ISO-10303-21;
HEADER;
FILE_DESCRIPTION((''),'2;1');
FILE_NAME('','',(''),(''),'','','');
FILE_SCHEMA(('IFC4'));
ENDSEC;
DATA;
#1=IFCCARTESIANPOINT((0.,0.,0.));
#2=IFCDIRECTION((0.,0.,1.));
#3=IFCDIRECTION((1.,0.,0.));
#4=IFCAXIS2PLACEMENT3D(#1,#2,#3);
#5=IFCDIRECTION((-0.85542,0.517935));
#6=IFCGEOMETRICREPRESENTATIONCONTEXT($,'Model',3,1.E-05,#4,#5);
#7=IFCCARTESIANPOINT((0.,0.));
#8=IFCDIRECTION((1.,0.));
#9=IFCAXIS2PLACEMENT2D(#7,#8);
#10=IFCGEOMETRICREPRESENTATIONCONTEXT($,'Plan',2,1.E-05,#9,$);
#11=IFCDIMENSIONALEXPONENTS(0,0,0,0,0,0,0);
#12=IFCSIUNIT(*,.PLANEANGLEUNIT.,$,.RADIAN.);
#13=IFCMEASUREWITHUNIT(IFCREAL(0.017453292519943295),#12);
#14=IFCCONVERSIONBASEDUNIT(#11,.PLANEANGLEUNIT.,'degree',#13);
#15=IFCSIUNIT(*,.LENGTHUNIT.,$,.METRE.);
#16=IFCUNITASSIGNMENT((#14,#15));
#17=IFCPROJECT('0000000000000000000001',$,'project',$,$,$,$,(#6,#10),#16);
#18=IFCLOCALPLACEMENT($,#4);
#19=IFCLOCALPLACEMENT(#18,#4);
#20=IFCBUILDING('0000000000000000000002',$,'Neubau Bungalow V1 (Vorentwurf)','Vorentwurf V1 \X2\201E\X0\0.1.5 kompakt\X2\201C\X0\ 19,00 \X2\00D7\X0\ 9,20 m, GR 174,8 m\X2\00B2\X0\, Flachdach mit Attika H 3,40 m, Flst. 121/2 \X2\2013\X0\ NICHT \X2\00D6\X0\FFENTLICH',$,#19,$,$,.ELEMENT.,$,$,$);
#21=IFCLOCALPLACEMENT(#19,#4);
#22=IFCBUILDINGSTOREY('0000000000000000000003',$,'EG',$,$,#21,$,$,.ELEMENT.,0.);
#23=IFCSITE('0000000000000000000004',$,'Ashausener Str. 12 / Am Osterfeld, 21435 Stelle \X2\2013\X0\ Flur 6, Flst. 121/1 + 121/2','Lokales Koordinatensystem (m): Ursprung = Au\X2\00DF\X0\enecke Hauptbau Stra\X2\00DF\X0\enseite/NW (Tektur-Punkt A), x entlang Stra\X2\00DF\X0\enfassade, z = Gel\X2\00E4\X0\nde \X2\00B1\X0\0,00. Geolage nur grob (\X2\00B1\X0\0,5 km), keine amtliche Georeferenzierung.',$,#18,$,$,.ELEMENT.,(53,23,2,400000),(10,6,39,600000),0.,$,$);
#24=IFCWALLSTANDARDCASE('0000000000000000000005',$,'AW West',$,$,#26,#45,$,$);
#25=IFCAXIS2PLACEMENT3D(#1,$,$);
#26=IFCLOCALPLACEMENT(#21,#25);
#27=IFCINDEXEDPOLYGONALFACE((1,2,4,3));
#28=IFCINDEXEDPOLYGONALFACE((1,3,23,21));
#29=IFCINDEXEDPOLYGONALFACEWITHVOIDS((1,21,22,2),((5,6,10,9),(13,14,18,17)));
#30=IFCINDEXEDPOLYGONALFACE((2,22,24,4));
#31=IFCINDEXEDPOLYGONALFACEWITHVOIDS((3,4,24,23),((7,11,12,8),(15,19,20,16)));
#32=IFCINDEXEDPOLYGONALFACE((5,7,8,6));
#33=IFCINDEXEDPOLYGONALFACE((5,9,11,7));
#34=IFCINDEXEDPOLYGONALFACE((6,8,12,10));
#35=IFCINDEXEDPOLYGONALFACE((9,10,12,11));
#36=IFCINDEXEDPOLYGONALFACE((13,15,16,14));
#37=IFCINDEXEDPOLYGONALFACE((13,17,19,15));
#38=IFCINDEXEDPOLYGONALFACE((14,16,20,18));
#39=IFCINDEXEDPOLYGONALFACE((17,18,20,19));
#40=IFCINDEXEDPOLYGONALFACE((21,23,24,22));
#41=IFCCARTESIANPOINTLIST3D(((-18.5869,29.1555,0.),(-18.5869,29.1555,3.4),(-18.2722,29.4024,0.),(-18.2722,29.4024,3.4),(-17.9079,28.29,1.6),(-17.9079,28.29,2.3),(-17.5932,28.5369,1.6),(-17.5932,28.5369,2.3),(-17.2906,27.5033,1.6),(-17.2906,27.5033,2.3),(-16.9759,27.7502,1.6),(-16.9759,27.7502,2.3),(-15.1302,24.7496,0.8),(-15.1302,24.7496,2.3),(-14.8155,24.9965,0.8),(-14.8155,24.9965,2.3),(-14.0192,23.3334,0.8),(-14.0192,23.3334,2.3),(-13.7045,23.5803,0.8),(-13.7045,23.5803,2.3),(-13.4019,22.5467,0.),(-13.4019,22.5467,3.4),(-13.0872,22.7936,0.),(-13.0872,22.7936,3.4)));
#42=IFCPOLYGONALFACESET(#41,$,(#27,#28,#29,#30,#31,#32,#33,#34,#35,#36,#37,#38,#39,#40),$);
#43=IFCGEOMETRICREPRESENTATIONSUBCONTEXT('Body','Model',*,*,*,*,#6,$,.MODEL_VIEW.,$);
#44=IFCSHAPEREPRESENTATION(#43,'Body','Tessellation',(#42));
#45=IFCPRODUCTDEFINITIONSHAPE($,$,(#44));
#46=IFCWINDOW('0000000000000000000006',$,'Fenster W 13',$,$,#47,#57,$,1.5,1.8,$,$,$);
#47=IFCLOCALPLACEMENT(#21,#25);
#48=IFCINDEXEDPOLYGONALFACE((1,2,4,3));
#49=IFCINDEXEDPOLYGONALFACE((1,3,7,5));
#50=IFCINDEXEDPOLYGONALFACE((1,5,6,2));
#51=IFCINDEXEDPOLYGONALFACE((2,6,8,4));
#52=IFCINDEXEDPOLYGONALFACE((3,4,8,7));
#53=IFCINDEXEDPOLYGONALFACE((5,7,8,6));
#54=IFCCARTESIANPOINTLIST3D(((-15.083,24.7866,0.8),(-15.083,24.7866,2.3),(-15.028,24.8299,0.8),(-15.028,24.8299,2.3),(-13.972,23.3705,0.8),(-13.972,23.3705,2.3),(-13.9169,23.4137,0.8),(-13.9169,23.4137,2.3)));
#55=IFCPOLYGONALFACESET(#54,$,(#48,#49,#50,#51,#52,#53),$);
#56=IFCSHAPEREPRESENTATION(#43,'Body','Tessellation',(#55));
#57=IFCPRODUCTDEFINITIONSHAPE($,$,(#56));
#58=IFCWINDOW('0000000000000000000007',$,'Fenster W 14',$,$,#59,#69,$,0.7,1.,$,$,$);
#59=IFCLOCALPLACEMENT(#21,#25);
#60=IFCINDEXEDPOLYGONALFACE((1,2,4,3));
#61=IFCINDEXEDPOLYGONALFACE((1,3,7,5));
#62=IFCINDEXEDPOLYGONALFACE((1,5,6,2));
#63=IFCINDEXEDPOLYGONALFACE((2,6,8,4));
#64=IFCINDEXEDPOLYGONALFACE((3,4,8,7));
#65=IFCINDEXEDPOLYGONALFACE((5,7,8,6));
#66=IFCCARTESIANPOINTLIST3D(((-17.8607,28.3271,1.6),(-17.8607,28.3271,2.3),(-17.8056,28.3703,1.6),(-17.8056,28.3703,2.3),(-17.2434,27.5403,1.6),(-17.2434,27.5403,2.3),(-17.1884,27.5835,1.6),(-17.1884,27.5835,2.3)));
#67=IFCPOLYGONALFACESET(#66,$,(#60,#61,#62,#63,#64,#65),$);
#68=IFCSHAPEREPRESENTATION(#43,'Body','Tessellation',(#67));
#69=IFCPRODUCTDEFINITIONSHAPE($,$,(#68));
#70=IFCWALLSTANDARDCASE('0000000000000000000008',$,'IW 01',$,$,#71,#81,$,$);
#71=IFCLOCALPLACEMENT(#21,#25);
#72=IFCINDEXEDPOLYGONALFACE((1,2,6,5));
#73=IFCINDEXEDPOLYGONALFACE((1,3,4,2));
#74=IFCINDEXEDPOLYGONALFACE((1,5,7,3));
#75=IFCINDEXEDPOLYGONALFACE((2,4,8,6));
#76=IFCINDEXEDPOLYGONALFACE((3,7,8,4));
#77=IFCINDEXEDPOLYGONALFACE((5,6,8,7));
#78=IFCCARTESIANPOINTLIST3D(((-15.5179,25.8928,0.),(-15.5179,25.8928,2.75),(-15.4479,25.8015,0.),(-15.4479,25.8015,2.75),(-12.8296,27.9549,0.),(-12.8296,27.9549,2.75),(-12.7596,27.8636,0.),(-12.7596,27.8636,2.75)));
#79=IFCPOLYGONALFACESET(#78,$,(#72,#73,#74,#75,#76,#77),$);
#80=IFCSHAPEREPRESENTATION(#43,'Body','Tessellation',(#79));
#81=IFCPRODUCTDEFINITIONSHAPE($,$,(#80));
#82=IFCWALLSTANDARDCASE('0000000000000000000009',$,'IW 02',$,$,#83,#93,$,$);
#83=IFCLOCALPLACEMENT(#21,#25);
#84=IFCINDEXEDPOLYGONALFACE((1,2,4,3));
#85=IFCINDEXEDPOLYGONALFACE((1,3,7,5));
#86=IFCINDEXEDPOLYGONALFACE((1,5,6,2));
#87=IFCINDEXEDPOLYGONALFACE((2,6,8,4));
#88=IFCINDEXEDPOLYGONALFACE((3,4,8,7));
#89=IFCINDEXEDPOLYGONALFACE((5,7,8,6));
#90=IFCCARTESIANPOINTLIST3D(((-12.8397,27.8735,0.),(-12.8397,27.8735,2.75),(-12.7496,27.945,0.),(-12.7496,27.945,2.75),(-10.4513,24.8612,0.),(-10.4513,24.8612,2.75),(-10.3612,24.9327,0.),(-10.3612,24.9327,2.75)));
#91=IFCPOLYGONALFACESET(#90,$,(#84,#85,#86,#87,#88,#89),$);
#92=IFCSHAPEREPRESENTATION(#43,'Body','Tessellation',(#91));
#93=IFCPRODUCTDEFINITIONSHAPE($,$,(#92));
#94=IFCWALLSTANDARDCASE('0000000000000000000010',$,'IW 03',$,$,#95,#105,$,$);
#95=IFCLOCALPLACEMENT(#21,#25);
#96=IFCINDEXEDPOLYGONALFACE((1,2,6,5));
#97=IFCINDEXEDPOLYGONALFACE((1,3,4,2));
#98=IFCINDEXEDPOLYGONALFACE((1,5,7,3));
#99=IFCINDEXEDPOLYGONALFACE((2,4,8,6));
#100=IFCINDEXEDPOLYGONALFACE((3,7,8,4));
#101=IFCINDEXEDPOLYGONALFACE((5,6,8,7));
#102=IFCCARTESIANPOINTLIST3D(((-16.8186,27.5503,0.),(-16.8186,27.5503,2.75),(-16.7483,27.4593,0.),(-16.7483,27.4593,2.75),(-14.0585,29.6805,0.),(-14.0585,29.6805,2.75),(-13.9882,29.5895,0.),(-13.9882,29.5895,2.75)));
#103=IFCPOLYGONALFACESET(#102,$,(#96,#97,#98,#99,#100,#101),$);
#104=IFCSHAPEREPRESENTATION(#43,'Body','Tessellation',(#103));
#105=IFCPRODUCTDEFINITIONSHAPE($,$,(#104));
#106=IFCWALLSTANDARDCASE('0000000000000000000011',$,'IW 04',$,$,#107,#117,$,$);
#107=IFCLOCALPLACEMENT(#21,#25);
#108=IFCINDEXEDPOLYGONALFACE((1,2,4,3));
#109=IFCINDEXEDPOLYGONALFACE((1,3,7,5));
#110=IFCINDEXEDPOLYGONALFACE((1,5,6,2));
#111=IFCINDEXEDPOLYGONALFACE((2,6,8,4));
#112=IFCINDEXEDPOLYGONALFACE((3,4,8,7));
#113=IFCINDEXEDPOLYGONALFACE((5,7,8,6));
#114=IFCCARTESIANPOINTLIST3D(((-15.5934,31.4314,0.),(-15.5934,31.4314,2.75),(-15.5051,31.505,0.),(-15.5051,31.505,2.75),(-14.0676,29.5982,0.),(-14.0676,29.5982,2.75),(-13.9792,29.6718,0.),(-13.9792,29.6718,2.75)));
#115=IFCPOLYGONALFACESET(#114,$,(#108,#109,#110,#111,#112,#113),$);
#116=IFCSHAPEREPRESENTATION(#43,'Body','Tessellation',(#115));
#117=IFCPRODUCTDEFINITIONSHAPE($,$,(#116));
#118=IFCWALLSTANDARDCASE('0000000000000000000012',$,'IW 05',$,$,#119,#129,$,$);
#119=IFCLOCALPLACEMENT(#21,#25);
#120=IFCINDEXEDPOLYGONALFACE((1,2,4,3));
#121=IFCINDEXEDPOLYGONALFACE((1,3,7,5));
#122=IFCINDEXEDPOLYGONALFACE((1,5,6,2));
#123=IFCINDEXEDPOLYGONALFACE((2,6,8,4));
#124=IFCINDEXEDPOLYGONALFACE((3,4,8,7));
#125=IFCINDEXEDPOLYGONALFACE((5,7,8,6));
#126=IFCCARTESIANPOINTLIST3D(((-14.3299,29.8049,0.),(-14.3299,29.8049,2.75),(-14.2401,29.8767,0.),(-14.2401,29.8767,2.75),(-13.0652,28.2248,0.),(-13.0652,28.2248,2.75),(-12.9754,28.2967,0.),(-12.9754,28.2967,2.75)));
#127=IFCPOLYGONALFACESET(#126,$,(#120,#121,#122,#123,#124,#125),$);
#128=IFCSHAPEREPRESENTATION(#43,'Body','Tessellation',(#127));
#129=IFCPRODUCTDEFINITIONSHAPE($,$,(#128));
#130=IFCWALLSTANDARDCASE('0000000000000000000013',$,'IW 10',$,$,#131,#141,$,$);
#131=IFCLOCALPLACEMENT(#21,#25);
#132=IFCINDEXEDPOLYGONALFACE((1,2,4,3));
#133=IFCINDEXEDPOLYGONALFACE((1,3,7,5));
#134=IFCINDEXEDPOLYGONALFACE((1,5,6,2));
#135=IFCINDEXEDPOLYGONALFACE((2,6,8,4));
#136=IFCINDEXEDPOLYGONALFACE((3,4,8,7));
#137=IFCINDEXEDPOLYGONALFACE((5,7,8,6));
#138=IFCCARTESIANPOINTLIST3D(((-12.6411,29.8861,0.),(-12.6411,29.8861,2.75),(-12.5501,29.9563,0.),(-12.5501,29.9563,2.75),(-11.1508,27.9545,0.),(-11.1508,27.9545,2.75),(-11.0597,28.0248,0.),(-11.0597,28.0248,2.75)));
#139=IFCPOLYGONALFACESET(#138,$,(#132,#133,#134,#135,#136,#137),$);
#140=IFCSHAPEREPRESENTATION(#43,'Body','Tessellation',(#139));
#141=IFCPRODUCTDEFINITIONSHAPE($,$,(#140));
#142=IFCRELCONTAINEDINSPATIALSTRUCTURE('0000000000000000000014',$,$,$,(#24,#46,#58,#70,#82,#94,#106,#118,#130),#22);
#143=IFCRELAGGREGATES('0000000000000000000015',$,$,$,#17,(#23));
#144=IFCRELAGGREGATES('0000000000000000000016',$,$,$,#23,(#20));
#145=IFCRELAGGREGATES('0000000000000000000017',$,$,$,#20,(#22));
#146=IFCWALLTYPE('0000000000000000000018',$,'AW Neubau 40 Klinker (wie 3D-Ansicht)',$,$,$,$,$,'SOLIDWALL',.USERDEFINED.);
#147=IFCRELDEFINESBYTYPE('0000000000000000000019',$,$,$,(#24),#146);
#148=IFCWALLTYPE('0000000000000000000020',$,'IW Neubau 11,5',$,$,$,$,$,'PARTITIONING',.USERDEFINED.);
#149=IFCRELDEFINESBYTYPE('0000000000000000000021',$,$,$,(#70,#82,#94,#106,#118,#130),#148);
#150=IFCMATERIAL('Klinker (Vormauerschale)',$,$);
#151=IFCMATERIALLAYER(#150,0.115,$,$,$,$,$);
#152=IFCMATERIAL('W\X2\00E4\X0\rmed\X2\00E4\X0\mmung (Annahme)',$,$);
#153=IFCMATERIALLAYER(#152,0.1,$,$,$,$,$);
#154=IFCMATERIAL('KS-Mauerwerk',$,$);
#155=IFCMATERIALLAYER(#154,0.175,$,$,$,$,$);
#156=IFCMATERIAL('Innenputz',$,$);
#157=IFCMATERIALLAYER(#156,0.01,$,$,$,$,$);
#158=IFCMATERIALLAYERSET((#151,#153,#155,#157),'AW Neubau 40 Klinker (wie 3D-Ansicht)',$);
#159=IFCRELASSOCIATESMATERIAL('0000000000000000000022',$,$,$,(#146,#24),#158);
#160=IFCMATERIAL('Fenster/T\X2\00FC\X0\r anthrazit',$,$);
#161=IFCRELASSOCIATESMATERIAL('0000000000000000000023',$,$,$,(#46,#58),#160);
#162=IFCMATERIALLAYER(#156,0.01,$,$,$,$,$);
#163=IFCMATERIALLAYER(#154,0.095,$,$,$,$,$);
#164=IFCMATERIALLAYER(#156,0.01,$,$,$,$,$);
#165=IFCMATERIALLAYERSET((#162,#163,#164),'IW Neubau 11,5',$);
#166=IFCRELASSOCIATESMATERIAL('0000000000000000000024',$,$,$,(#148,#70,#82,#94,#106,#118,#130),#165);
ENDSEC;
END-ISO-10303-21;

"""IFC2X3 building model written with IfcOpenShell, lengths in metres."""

from ifc_helpers import new_model, entity, si_unit, converted_unit, direction, frame, origin_with_axes, origin_2d_with_axis, place, context, subcontext, project, spatial, polyline, outline, extrude, material, layer, layer_set, layer_usage, type_object, element, fill, save


model = new_model("IFC2X3")

# Units and contexts
model_context = context("Model", 3, precision=1e-05, world=origin_with_axes(), true_north=direction((-0.85542, 0.517935)))
plan_context = context("Plan", 2, precision=1e-05, world=origin_2d_with_axis())
body_context = subcontext(model_context, "Body", "Model", "MODEL_VIEW")
ifc_project = project(units=[converted_unit("PLANEANGLEUNIT", "degree", entity("IfcReal", 0.017453292519943295), si_unit("PLANEANGLEUNIT", "RADIAN"), dimensions=[0, 0, 0, 0, 0, 0, 0]), si_unit("LENGTHUNIT", "METRE")], contexts=[model_context, plan_context])

# Site, building, storey
site_placement = place(None, origin_with_axes())
site = spatial("IfcSite", under=ifc_project, at=site_placement, Name="Ashausener Str. 12 / Am Osterfeld, 21435 Stelle – Flur 6, Flst. 121/1 + 121/2", Description="Lokales Koordinatensystem (m): Ursprung = Außenecke Hauptbau Straßenseite/NW (Tektur-Punkt A), x entlang Straßenfassade, z = Gelände ±0,00. Geolage nur grob (±0,5 km), keine amtliche Georeferenzierung.", CompositionType="ELEMENT", RefLatitude=(53, 23, 2, 400000), RefLongitude=(10, 6, 39, 600000), RefElevation=0.0)
building_placement = place(site_placement, origin_with_axes())
building = spatial("IfcBuilding", under=site, at=building_placement, Name="Neubau Bungalow V1 (Vorentwurf)", Description="Vorentwurf V1 „0.1.5 kompakt“ 19,00 × 9,20 m, GR 174,8 m², Flachdach mit Attika H 3,40 m, Flst. 121/2 – NICHT ÖFFENTLICH", CompositionType="ELEMENT")
storey_placement = place(building_placement, origin_with_axes())
storey = spatial("IfcBuildingStorey", under=building, at=storey_placement, Name="EG", CompositionType="ELEMENT", Elevation=0.0)

# Wall, openings, windows
ifc_material_1 = material(Name="Klinker (Vormauerschale)")
ifc_layer_1 = layer(ifc_material_1, 0.115)
ifc_material_2 = material(Name="Wärmedämmung (Annahme)")
ifc_layer_2 = layer(ifc_material_2, 0.1)
ifc_material_3 = material(Name="KS-Mauerwerk")
ifc_layer_3 = layer(ifc_material_3, 0.175)
ifc_material_4 = material(Name="Innenputz")
ifc_layer_4 = layer(ifc_material_4, 0.01)
ifc_layer_set_1 = layer_set([ifc_layer_1, ifc_layer_2, ifc_layer_3, ifc_layer_4], Name="AW Neubau 40 Klinker (wie 3D-Ansicht)")
wall_type_1 = type_object("IfcWallType", Name="AW Neubau 40 Klinker (wie 3D-Ansicht)", ElementType="SOLIDWALL", PredefinedType="USERDEFINED", material=ifc_layer_set_1)
ifc_material_5 = material(Name="Fenster/Tür anthrazit")
ifc_layer_usage_1 = layer_usage(ifc_layer_set_1, "AXIS2", "POSITIVE", 0.0)
wall_1_placement = place(storey_placement, frame((-18.5869, 29.1555, 0.0), z_axis=(0.0, 0.0, 1.0), x_axis=(0.617258, -0.786761, 0.0)))
wall_1 = element("IfcWallStandardCase", 1, at=wall_1_placement, inside=storey, type_object=wall_type_1, material=ifc_layer_usage_1, Name="AW West", context=body_context, shape_type="SweptSolid", body=[
    extrude(outline(polyline([(0.0, 0.0), (0.0, 0.4), (8.4, 0.4), (8.4, 0.0), (0.0, 0.0)])), origin_with_axes(), (0.0, 0.0, 1.0), 3.4),
])
opening_1_placement = place(wall_1_placement, frame((5.6, -0.1, 0.8), z_axis=(0.0, 0.0, 1.0), x_axis=(1.0, 0.0, 0.0)))
opening_1 = element("IfcOpeningElement", 2, at=opening_1_placement, cuts=wall_1, context=body_context, shape_type="SweptSolid", body=[
    extrude(outline(polyline([(0.0, 0.0), (0.0, 0.6), (1.8, 0.6), (1.8, 0.0), (0.0, 0.0)])), origin_with_axes(), (0.0, 0.0, 1.0), 1.5),
])
opening_2_placement = place(wall_1_placement, frame((1.1, -0.1, 1.6), z_axis=(0.0, 0.0, 1.0), x_axis=(1.0, 0.0, 0.0)))
opening_2 = element("IfcOpeningElement", 3, at=opening_2_placement, cuts=wall_1, context=body_context, shape_type="SweptSolid", body=[
    extrude(outline(polyline([(0.0, 0.0), (0.0, 0.6), (1.0, 0.6), (1.0, 0.0), (0.0, 0.0)])), origin_with_axes(), (0.0, 0.0, 1.0), 0.7),
])
window_1_placement = place(storey_placement, frame((-15.083, 24.7866, 0.8), z_axis=(0.0, 0.0, 1.0), x_axis=(0.617258, -0.786761, 0.0)))
window_1 = element("IfcWindow", 4, at=window_1_placement, inside=storey, material=ifc_material_5, Name="Fenster W 13", OverallHeight=1.5, OverallWidth=1.8, context=body_context, shape_type="SweptSolid", body=[
    extrude(outline(polyline([(0.0, 0.0), (0.0, 0.07), (1.8, 0.07), (1.8, 0.0), (0.0, 0.0)])), origin_with_axes(), (0.0, 0.0, 1.0), 1.5),
])
fill(opening_1, window_1)
window_2_placement = place(storey_placement, frame((-17.8607, 28.3271, 1.6), z_axis=(0.0, 0.0, 1.0), x_axis=(0.617258, -0.786761, 0.0)))
window_2 = element("IfcWindow", 5, at=window_2_placement, inside=storey, material=ifc_material_5, Name="Fenster W 14", OverallHeight=0.7, OverallWidth=1.0, context=body_context, shape_type="SweptSolid", body=[
    extrude(outline(polyline([(0.0, 0.0), (0.0, 0.07), (1.0, 0.07), (1.0, 0.0), (0.0, 0.0)])), origin_with_axes(), (0.0, 0.0, 1.0), 0.7),
])
fill(opening_2, window_2)

# Walls
ifc_layer_5 = layer(ifc_material_4, 0.01)
ifc_layer_6 = layer(ifc_material_3, 0.095)
ifc_layer_7 = layer(ifc_material_4, 0.01)
ifc_layer_set_2 = layer_set([ifc_layer_5, ifc_layer_6, ifc_layer_7], Name="IW Neubau 11,5")
ifc_layer_usage_2 = layer_usage(ifc_layer_set_2, "AXIS2", "POSITIVE", -0.0575)
wall_type_2 = type_object("IfcWallType", Name="IW Neubau 11,5", ElementType="PARTITIONING", PredefinedType="USERDEFINED", material=ifc_layer_set_2)
wall_2_placement = place(storey_placement, frame((-15.4829, 25.8471, 0.0), z_axis=(0.0, 0.0, 1.0), x_axis=(0.793448, 0.608638, 0.0)))
element("IfcWallStandardCase", 6, at=wall_2_placement, inside=storey, type_object=wall_type_2, material=ifc_layer_usage_2, Name="IW 01", context=body_context, shape_type="SweptSolid", body=[
    extrude(outline(polyline([(0.0, 0.0), (0.0, 0.115), (3.3881, 0.115), (3.3881, 0.0), (0.0, 0.0)])), frame((0.0, -0.0575, 0.0), z_axis=(0.0, 0.0, 1.0), x_axis=(1.0, 0.0, 0.0)), (0.0, 0.0, 1.0), 2.75),
])
ifc_layer_usage_3 = layer_usage(ifc_layer_set_2, "AXIS2", "POSITIVE", -0.0575)
wall_3_placement = place(storey_placement, frame((-12.7946, 27.9093, 0.0), z_axis=(0.0, 0.0, 1.0), x_axis=(0.621281, -0.783588, 0.0)))
element("IfcWallStandardCase", 7, at=wall_3_placement, inside=storey, type_object=wall_type_2, material=ifc_layer_usage_3, Name="IW 02", context=body_context, shape_type="SweptSolid", body=[
    extrude(outline(polyline([(0.0, 0.0), (0.0, 0.115), (3.8443, 0.115), (3.8443, 0.0), (0.0, 0.0)])), frame((0.0, -0.0575, 0.0), z_axis=(0.0, 0.0, 1.0), x_axis=(1.0, 0.0, 0.0)), (0.0, 0.0, 1.0), 2.75),
])
ifc_layer_usage_4 = layer_usage(ifc_layer_set_2, "AXIS2", "POSITIVE", -0.0575)
wall_4_placement = place(storey_placement, frame((-16.7834, 27.5048, 0.0), z_axis=(0.0, 0.0, 1.0), x_axis=(0.791644, 0.610982, 0.0)))
element("IfcWallStandardCase", 8, at=wall_4_placement, inside=storey, type_object=wall_type_2, material=ifc_layer_usage_4, Name="IW 03", context=body_context, shape_type="SweptSolid", body=[
    extrude(outline(polyline([(0.0, 0.0), (0.0, 0.115), (3.4865, 0.115), (3.4865, 0.0), (0.0, 0.0)])), frame((0.0, -0.0575, 0.0), z_axis=(0.0, 0.0, 1.0), x_axis=(1.0, 0.0, 0.0)), (0.0, 0.0, 1.0), 2.75),
])
ifc_layer_usage_5 = layer_usage(ifc_layer_set_2, "AXIS2", "POSITIVE", -0.0575)
wall_5_placement = place(storey_placement, frame((-14.0234, 29.635, 0.0), z_axis=(0.0, 0.0, 1.0), x_axis=(-0.63974, 0.768591, 0.0)))
element("IfcWallStandardCase", 9, at=wall_5_placement, inside=storey, type_object=wall_type_2, material=ifc_layer_usage_5, Name="IW 04", context=body_context, shape_type="SweptSolid", body=[
    extrude(outline(polyline([(0.0, 0.0), (0.0, 0.115), (2.3852, 0.115), (2.3852, 0.0), (0.0, 0.0)])), frame((0.0, -0.0575, 0.0), z_axis=(0.0, 0.0, 1.0), x_axis=(1.0, 0.0, 0.0)), (0.0, 0.0, 1.0), 2.75),
])
ifc_layer_usage_6 = layer_usage(ifc_layer_set_2, "AXIS2", "POSITIVE", -0.0575)
wall_6_placement = place(storey_placement, frame((-14.285, 29.8408, 0.0), z_axis=(0.0, 0.0, 1.0), x_axis=(0.624886, -0.780716, 0.0)))
element("IfcWallStandardCase", 10, at=wall_6_placement, inside=storey, type_object=wall_type_2, material=ifc_layer_usage_6, Name="IW 05", context=body_context, shape_type="SweptSolid", body=[
    extrude(outline(polyline([(0.0, 0.0), (0.0, 0.115), (2.0239, 0.115), (2.0239, 0.0), (0.0, 0.0)])), frame((0.0, -0.0575, 0.0), z_axis=(0.0, 0.0, 1.0), x_axis=(1.0, 0.0, 0.0)), (0.0, 0.0, 1.0), 2.75),
])
ifc_layer_usage_7 = layer_usage(ifc_layer_set_2, "AXIS2", "POSITIVE", -0.0575)
wall_7_placement = place(storey_placement, frame((-12.5956, 29.9212, 0.0), z_axis=(0.0, 0.0, 1.0), x_axis=(0.610886, -0.791719, 0.0)))
element("IfcWallStandardCase", 11, at=wall_7_placement, inside=storey, type_object=wall_type_2, material=ifc_layer_usage_7, Name="IW 10", context=body_context, shape_type="SweptSolid", body=[
    extrude(outline(polyline([(0.0, 0.0), (0.0, 0.115), (2.4397, 0.115), (2.4397, 0.0), (0.0, 0.0)])), frame((0.0, -0.0575, 0.0), z_axis=(0.0, 0.0, 1.0), x_axis=(1.0, 0.0, 0.0)), (0.0, 0.0, 1.0), 2.75),
])

save(model, "model.ifc")
